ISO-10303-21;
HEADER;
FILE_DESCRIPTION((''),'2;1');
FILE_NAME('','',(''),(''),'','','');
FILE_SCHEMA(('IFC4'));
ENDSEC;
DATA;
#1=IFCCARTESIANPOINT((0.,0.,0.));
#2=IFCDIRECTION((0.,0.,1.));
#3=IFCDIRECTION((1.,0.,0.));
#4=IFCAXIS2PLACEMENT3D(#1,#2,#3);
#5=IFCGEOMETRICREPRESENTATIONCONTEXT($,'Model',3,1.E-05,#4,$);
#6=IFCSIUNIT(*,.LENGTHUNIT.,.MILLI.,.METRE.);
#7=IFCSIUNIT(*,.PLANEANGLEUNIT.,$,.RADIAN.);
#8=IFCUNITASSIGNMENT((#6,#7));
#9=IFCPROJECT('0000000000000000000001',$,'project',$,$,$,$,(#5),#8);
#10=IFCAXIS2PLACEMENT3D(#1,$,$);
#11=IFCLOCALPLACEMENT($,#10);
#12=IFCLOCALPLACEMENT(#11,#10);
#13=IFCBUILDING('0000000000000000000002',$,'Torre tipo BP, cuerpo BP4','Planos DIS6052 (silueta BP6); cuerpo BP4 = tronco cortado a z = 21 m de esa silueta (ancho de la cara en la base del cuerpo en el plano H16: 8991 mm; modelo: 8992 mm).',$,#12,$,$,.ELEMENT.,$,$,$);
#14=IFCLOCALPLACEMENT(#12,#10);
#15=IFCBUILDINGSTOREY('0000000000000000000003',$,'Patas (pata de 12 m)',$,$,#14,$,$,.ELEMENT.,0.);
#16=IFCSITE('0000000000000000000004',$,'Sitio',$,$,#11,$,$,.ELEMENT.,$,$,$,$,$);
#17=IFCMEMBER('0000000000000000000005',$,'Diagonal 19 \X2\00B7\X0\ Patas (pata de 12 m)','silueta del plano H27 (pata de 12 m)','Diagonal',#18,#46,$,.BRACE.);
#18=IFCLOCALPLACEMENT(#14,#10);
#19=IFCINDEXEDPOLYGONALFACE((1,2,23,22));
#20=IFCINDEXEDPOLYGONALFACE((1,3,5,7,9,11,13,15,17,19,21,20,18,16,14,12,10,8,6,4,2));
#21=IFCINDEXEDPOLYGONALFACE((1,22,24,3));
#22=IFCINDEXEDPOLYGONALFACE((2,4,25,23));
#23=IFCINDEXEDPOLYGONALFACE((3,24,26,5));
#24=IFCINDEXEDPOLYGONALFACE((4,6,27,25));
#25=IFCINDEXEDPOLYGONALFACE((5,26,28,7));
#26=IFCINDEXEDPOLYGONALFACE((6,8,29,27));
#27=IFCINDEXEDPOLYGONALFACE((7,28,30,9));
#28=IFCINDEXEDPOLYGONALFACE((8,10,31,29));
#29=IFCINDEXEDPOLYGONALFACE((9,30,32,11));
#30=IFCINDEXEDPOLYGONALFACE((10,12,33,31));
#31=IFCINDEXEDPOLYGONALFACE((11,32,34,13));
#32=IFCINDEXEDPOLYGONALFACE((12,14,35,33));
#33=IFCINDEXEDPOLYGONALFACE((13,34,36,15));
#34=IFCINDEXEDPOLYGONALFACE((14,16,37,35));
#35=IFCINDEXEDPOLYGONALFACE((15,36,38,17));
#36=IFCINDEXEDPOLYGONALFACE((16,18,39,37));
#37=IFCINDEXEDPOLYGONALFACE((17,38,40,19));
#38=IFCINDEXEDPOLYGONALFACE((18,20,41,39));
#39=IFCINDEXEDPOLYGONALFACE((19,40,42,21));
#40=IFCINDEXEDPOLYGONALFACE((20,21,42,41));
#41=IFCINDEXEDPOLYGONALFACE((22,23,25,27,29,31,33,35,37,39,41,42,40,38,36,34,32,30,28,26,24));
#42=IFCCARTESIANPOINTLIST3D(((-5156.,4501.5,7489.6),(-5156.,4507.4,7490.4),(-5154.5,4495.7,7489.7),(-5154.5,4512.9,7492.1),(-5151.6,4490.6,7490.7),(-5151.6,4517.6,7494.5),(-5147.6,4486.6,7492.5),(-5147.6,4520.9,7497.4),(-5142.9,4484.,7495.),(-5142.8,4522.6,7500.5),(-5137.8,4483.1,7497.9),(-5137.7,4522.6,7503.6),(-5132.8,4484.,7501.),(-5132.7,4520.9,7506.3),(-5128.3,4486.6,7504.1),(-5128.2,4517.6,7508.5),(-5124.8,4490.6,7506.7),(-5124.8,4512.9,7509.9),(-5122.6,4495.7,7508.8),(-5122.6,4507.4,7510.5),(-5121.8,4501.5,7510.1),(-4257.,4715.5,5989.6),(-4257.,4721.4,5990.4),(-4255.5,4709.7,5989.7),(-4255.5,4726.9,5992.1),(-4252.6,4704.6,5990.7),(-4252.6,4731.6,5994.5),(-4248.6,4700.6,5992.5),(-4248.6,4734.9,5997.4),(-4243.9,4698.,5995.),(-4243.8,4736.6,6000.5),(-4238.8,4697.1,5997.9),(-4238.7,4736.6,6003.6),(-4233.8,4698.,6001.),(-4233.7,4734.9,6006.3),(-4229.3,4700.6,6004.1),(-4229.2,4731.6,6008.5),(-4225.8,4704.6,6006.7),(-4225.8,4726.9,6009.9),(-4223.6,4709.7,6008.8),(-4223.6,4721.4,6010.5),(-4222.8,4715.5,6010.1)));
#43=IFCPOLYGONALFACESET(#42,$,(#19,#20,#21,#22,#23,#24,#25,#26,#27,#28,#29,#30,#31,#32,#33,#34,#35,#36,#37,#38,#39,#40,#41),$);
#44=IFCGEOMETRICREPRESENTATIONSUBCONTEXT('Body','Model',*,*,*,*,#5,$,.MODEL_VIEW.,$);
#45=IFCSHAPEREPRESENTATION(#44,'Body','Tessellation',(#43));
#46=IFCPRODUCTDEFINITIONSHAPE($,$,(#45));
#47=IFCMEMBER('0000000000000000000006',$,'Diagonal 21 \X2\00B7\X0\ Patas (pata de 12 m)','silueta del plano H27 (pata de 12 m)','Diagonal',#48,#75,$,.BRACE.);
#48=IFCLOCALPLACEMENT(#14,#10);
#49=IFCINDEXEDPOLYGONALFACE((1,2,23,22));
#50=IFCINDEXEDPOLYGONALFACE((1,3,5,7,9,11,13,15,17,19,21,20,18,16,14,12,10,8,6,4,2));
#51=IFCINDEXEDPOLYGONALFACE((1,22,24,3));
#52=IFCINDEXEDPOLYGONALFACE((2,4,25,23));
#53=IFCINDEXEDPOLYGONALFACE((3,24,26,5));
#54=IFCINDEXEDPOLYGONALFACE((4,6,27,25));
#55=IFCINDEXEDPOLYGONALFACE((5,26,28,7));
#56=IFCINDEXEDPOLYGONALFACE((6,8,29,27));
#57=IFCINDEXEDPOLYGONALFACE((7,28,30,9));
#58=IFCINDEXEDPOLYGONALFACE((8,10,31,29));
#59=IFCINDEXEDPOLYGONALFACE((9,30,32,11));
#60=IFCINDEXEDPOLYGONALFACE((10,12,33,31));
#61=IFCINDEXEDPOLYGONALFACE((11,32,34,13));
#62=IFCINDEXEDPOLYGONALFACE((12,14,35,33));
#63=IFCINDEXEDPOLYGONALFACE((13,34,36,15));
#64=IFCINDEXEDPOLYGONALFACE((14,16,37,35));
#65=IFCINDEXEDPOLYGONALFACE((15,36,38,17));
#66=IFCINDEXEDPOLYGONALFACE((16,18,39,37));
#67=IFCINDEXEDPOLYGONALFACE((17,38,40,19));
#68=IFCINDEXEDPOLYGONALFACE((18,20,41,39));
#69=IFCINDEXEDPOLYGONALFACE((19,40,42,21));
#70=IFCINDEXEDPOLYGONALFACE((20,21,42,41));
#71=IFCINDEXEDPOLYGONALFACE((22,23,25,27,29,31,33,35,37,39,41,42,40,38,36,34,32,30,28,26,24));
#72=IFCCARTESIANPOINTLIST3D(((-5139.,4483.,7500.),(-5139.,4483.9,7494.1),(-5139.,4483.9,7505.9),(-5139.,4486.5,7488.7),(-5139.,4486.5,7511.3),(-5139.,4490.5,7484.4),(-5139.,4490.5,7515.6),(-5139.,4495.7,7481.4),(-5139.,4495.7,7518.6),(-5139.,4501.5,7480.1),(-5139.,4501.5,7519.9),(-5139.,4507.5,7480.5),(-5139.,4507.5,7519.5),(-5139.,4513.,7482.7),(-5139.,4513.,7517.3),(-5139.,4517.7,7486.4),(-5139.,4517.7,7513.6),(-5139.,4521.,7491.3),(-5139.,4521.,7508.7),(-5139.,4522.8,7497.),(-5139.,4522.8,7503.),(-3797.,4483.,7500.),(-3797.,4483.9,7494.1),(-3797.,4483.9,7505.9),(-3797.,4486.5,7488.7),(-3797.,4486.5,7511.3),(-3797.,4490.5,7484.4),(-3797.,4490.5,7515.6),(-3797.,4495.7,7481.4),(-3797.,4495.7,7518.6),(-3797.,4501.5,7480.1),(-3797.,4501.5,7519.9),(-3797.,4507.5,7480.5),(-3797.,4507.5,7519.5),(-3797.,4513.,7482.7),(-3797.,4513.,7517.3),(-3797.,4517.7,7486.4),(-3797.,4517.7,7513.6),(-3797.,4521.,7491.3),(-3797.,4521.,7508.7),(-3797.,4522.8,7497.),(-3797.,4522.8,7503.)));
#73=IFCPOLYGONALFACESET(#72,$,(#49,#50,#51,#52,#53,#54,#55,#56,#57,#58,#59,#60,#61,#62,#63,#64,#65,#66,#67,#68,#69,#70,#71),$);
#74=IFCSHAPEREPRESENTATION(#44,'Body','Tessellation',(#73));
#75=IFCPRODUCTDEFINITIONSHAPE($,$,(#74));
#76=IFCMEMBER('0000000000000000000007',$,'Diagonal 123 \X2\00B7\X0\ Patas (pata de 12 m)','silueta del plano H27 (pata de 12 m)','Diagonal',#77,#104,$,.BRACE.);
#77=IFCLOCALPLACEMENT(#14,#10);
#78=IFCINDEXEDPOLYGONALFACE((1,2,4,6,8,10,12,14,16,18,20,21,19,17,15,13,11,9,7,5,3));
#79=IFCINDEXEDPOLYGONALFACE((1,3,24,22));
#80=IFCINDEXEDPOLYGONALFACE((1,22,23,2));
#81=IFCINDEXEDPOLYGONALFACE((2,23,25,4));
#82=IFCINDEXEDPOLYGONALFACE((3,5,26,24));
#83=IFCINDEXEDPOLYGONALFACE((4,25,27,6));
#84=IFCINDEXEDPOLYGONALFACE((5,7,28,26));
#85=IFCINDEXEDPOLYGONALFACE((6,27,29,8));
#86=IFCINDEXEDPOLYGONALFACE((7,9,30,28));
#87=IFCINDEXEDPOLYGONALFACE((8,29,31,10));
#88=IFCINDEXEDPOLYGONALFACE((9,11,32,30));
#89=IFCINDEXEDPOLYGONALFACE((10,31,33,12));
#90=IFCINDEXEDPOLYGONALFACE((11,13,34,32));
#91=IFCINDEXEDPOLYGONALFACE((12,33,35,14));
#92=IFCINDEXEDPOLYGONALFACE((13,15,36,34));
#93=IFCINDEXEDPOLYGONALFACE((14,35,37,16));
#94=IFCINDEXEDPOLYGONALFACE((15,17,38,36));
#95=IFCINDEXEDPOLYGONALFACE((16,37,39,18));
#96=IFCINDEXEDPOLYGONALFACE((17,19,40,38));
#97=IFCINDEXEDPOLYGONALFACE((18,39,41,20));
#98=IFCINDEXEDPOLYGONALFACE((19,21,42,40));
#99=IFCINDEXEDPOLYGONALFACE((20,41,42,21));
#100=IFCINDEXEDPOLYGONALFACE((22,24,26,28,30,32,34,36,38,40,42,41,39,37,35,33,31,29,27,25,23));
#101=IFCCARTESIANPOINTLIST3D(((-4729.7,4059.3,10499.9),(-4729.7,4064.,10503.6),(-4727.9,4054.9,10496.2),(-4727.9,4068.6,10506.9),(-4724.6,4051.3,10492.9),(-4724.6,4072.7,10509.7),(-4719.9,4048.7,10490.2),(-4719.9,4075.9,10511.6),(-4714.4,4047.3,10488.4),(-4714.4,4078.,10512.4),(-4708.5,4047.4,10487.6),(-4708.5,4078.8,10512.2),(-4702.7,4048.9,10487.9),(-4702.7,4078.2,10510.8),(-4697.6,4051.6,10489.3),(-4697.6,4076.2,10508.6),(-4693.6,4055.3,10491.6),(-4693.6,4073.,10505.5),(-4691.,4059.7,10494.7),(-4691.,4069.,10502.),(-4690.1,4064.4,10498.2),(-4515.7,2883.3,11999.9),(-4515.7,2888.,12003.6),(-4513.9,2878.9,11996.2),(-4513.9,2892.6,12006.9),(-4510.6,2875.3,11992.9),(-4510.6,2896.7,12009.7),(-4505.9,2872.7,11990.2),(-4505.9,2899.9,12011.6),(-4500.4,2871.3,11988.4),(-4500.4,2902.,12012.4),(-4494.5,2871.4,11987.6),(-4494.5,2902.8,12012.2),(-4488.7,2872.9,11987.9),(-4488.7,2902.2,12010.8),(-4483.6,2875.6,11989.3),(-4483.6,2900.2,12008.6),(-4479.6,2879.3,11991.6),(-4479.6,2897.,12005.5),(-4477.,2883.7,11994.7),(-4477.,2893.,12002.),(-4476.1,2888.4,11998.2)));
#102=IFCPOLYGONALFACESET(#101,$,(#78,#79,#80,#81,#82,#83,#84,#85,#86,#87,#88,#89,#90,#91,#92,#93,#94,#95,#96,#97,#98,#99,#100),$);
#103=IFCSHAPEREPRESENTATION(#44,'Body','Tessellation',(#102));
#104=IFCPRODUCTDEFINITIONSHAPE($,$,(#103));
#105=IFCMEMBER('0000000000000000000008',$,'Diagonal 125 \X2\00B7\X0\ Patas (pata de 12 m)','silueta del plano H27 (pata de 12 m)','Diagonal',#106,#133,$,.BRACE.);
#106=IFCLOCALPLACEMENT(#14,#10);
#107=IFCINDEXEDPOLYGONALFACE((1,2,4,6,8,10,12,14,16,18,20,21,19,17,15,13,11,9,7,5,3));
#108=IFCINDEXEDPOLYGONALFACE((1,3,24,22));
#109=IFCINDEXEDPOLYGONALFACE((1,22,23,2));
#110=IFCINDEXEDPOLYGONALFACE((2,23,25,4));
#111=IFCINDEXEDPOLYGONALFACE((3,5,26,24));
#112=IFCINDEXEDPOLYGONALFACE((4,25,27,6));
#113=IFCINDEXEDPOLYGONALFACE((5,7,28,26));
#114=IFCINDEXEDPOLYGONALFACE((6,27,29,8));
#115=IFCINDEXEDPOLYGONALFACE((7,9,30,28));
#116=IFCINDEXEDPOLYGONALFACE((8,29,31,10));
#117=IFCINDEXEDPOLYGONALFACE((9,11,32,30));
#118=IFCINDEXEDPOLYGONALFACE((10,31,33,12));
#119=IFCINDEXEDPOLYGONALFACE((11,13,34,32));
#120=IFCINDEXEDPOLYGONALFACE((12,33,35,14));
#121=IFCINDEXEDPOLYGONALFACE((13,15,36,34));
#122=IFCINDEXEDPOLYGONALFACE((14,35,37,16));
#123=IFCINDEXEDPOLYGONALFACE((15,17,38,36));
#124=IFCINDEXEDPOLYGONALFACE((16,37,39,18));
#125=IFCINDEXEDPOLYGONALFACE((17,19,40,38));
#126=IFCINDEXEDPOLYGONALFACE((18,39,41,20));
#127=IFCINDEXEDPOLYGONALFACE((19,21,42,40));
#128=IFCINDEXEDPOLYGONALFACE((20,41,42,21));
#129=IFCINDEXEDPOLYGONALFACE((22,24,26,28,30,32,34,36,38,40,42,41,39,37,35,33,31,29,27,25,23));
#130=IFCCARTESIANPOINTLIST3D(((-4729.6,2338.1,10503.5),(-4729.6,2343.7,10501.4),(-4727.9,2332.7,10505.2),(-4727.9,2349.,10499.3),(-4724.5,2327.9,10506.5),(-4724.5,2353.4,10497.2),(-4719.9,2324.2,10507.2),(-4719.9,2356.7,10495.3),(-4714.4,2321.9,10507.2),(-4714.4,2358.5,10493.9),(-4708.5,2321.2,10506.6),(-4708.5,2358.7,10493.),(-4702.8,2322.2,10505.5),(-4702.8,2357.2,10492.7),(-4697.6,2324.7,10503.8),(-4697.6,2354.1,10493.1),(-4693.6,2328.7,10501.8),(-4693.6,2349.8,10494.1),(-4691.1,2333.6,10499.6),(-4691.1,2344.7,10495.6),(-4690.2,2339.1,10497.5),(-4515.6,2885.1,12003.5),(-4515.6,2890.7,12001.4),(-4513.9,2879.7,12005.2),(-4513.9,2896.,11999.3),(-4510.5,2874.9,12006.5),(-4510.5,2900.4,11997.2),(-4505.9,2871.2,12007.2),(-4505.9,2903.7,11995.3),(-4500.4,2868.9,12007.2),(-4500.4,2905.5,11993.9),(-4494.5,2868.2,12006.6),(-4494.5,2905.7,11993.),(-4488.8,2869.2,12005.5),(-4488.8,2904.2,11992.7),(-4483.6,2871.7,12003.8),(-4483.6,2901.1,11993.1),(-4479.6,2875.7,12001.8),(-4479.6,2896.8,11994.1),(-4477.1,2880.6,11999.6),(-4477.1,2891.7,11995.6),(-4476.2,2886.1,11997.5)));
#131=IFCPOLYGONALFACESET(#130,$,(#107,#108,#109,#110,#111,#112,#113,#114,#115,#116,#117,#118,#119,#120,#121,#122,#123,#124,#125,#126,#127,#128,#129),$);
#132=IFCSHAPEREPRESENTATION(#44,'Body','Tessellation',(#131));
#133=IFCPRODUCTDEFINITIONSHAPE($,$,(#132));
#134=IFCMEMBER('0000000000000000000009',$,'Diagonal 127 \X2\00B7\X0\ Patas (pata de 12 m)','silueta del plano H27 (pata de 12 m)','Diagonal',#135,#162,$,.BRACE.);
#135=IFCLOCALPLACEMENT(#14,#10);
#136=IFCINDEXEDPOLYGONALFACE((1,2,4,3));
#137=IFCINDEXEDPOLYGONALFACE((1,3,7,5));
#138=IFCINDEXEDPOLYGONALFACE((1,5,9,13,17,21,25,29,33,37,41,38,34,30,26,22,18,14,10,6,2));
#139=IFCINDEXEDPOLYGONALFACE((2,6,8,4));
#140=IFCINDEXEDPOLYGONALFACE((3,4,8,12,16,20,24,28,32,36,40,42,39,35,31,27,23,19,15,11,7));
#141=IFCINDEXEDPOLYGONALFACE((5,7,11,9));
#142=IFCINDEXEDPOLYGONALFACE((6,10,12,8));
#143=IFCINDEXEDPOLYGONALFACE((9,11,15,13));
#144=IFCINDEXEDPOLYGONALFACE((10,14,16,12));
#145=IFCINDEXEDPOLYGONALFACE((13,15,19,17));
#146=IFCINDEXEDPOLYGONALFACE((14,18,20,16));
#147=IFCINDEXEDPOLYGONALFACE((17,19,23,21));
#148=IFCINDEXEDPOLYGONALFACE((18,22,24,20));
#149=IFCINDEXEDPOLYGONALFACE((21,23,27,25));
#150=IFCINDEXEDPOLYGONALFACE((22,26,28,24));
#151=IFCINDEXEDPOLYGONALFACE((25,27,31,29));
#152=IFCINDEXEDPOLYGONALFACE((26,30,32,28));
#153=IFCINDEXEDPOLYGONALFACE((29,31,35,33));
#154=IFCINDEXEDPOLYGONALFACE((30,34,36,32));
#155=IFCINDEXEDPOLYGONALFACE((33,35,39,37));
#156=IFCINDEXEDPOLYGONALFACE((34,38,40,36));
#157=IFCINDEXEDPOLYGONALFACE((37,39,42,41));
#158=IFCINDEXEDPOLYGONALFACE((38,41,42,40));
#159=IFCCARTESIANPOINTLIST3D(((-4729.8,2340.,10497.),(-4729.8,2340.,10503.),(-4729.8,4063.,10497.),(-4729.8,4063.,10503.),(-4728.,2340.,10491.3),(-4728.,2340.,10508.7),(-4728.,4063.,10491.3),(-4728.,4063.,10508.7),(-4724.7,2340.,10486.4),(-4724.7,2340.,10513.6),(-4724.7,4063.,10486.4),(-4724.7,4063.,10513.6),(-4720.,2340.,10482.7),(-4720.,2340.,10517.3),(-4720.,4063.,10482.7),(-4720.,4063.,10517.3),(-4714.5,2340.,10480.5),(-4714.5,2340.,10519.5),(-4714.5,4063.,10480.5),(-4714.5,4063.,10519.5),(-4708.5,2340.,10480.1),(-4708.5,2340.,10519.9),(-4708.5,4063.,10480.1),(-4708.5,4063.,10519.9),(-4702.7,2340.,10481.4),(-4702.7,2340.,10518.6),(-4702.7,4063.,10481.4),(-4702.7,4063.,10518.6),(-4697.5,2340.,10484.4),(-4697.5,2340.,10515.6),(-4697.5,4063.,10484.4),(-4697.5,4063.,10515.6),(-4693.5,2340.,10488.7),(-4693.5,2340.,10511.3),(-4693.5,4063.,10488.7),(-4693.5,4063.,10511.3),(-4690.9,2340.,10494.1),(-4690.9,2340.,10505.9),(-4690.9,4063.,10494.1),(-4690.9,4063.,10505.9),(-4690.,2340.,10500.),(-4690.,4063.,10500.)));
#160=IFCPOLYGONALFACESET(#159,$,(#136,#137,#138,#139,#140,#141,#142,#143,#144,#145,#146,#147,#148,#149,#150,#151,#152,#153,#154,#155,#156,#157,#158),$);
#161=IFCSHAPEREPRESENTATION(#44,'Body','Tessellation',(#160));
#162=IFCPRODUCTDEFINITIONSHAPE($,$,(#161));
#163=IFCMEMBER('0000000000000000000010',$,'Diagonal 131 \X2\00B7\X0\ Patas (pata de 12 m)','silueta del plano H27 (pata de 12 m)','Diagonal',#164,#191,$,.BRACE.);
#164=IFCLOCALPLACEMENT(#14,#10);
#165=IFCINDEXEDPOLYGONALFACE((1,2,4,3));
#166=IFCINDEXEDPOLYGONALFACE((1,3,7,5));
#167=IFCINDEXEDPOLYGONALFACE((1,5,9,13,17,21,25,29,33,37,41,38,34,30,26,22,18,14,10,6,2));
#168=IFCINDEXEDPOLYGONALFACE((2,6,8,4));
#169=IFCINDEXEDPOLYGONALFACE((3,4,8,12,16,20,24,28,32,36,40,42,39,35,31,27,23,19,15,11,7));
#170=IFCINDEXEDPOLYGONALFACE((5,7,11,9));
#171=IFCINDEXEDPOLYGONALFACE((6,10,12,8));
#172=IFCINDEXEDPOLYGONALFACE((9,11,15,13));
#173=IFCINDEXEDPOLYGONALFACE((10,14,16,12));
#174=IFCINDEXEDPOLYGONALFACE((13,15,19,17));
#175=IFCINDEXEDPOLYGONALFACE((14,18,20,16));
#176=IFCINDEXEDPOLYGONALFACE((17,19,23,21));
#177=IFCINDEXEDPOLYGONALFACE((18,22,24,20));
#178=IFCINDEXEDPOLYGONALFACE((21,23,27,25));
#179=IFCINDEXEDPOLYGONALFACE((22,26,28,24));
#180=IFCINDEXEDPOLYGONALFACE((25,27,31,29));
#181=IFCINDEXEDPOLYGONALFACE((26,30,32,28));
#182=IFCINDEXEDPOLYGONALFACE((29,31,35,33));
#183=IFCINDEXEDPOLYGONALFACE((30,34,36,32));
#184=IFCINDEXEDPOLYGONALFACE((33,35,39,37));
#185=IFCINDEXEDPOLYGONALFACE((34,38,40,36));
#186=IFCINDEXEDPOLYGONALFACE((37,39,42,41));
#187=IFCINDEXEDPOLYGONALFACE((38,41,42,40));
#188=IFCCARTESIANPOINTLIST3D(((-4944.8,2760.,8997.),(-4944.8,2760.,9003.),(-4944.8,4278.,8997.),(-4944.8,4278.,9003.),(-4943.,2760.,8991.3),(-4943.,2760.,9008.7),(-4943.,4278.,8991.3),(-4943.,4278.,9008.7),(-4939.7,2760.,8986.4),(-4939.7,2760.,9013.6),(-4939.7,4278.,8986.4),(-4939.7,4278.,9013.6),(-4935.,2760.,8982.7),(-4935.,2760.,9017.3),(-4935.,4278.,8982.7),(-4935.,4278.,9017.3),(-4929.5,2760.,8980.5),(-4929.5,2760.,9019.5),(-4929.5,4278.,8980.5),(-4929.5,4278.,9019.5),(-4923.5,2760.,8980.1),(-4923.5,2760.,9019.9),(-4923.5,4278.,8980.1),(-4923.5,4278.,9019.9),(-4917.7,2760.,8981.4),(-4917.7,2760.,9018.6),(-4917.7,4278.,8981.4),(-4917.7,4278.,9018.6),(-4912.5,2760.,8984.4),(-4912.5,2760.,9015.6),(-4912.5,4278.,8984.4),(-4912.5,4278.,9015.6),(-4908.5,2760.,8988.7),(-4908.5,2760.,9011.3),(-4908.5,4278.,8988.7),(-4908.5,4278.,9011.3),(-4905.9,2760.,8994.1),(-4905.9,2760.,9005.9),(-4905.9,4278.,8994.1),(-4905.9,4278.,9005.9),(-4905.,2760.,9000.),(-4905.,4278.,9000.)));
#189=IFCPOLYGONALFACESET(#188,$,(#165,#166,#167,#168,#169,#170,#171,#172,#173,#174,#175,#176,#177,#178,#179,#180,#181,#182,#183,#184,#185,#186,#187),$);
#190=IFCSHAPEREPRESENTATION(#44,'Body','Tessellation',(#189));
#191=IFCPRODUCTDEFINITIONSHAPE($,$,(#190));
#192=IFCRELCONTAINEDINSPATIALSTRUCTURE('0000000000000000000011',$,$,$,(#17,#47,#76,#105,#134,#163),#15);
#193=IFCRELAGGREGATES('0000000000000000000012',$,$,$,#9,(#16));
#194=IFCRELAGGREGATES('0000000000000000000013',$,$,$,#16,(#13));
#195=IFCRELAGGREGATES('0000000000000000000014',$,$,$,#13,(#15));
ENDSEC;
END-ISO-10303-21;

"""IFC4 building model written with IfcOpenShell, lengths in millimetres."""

from ifc_helpers import new_model, si_unit, frame, origin, origin_with_axes, place, context, subcontext, project, spatial, circle, extrude, element, save


model = new_model("IFC4")

# Units and contexts
model_context = context("Model", 3, precision=1e-05, world=origin_with_axes())
body_context = subcontext(model_context, "Body", "Model", "MODEL_VIEW")
ifc_project = project(units=[si_unit("LENGTHUNIT", "METRE", prefix="MILLI"), si_unit("PLANEANGLEUNIT", "RADIAN")], contexts=[model_context])

# Site, building, storey
site_placement = place(None, origin())
site = spatial("IfcSite", under=ifc_project, at=site_placement, Name="Sitio", CompositionType="ELEMENT")
building_placement = place(site_placement, origin())
building = spatial("IfcBuilding", under=site, at=building_placement, Name="Torre tipo BP, cuerpo BP4", Description="Planos DIS6052 (silueta BP6); cuerpo BP4 = tronco cortado a z = 21 m de esa silueta (ancho de la cara en la base del cuerpo en el plano H16: 8991 mm; modelo: 8992 mm).", CompositionType="ELEMENT")
storey_placement = place(building_placement, origin())
storey = spatial("IfcBuildingStorey", under=building, at=storey_placement, Name="Patas (pata de 12 m)", CompositionType="ELEMENT", Elevation=0.0)

# Members
member_1_placement = place(storey_placement, frame((-4240.0, 4717.0, 6000.0), z_axis=(-0.510269, -0.121466, 0.851394), x_axis=(0.062442, -0.992596, -0.104186)))
element("IfcMember", 1, at=member_1_placement, inside=storey, Name="Diagonal 19 · Patas (pata de 12 m)", Description="silueta del plano H27 (pata de 12 m)", ObjectType="Diagonal", PredefinedType="BRACE", context=body_context, shape_type="SweptSolid", body=[
    extrude(circle(Radius=20.0), None, (0.0, 0.0, 1.0), 1761.8),
])
member_2_placement = place(storey_placement, frame((-5139.0, 4503.0, 7500.0), z_axis=(1.0, 0.0, 0.0), x_axis=(0.0, -1.0, 0.0)))
element("IfcMember", 2, at=member_2_placement, inside=storey, Name="Diagonal 21 · Patas (pata de 12 m)", Description="silueta del plano H27 (pata de 12 m)", ObjectType="Diagonal", PredefinedType="BRACE", context=body_context, shape_type="SweptSolid", body=[
    extrude(circle(Radius=20.0), None, (0.0, 0.0, 1.0), 1342.0),
])
member_3_placement = place(storey_placement, frame((-4710.0, 4063.0, 10500.0), z_axis=(0.111574, -0.613135, 0.78206), x_axis=(0.993756, 0.06884, -0.087806)))
element("IfcMember", 3, at=member_3_placement, inside=storey, Name="Diagonal 123 · Patas (pata de 12 m)", Description="silueta del plano H27 (pata de 12 m)", ObjectType="Diagonal", PredefinedType="BRACE", context=body_context, shape_type="SweptSolid", body=[
    extrude(circle(Radius=20.0), None, (0.0, 0.0, 1.0), 1918.0),
])
member_4_placement = place(storey_placement, frame((-4496.0, 2887.0, 12000.0), z_axis=(-0.132845, -0.339561, -0.931155), x_axis=(0.991137, -0.045512, -0.124805)))
element("IfcMember", 4, at=member_4_placement, inside=storey, Name="Diagonal 125 · Patas (pata de 12 m)", Description="silueta del plano H27 (pata de 12 m)", ObjectType="Diagonal", PredefinedType="BRACE", context=body_context, shape_type="SweptSolid", body=[
    extrude(circle(Radius=20.0), None, (0.0, 0.0, 1.0), 1610.9),
])
member_5_placement = place(storey_placement, frame((-4710.0, 2340.0, 10500.0), z_axis=(0.0, 1.0, 0.0), x_axis=(1.0, 0.0, 0.0)))
element("IfcMember", 5, at=member_5_placement, inside=storey, Name="Diagonal 127 · Patas (pata de 12 m)", Description="silueta del plano H27 (pata de 12 m)", ObjectType="Diagonal", PredefinedType="BRACE", context=body_context, shape_type="SweptSolid", body=[
    extrude(circle(Radius=20.0), None, (0.0, 0.0, 1.0), 1723.0),
])
member_6_placement = place(storey_placement, frame((-4925.0, 4278.0, 9000.0), z_axis=(0.0, -1.0, 0.0), x_axis=(1.0, 0.0, 0.0)))
element("IfcMember", 6, at=member_6_placement, inside=storey, Name="Diagonal 131 · Patas (pata de 12 m)", Description="silueta del plano H27 (pata de 12 m)", ObjectType="Diagonal", PredefinedType="BRACE", context=body_context, shape_type="SweptSolid", body=[
    extrude(circle(Radius=20.0), None, (0.0, 0.0, 1.0), 1518.0),
])

save(model, "model.ifc")
